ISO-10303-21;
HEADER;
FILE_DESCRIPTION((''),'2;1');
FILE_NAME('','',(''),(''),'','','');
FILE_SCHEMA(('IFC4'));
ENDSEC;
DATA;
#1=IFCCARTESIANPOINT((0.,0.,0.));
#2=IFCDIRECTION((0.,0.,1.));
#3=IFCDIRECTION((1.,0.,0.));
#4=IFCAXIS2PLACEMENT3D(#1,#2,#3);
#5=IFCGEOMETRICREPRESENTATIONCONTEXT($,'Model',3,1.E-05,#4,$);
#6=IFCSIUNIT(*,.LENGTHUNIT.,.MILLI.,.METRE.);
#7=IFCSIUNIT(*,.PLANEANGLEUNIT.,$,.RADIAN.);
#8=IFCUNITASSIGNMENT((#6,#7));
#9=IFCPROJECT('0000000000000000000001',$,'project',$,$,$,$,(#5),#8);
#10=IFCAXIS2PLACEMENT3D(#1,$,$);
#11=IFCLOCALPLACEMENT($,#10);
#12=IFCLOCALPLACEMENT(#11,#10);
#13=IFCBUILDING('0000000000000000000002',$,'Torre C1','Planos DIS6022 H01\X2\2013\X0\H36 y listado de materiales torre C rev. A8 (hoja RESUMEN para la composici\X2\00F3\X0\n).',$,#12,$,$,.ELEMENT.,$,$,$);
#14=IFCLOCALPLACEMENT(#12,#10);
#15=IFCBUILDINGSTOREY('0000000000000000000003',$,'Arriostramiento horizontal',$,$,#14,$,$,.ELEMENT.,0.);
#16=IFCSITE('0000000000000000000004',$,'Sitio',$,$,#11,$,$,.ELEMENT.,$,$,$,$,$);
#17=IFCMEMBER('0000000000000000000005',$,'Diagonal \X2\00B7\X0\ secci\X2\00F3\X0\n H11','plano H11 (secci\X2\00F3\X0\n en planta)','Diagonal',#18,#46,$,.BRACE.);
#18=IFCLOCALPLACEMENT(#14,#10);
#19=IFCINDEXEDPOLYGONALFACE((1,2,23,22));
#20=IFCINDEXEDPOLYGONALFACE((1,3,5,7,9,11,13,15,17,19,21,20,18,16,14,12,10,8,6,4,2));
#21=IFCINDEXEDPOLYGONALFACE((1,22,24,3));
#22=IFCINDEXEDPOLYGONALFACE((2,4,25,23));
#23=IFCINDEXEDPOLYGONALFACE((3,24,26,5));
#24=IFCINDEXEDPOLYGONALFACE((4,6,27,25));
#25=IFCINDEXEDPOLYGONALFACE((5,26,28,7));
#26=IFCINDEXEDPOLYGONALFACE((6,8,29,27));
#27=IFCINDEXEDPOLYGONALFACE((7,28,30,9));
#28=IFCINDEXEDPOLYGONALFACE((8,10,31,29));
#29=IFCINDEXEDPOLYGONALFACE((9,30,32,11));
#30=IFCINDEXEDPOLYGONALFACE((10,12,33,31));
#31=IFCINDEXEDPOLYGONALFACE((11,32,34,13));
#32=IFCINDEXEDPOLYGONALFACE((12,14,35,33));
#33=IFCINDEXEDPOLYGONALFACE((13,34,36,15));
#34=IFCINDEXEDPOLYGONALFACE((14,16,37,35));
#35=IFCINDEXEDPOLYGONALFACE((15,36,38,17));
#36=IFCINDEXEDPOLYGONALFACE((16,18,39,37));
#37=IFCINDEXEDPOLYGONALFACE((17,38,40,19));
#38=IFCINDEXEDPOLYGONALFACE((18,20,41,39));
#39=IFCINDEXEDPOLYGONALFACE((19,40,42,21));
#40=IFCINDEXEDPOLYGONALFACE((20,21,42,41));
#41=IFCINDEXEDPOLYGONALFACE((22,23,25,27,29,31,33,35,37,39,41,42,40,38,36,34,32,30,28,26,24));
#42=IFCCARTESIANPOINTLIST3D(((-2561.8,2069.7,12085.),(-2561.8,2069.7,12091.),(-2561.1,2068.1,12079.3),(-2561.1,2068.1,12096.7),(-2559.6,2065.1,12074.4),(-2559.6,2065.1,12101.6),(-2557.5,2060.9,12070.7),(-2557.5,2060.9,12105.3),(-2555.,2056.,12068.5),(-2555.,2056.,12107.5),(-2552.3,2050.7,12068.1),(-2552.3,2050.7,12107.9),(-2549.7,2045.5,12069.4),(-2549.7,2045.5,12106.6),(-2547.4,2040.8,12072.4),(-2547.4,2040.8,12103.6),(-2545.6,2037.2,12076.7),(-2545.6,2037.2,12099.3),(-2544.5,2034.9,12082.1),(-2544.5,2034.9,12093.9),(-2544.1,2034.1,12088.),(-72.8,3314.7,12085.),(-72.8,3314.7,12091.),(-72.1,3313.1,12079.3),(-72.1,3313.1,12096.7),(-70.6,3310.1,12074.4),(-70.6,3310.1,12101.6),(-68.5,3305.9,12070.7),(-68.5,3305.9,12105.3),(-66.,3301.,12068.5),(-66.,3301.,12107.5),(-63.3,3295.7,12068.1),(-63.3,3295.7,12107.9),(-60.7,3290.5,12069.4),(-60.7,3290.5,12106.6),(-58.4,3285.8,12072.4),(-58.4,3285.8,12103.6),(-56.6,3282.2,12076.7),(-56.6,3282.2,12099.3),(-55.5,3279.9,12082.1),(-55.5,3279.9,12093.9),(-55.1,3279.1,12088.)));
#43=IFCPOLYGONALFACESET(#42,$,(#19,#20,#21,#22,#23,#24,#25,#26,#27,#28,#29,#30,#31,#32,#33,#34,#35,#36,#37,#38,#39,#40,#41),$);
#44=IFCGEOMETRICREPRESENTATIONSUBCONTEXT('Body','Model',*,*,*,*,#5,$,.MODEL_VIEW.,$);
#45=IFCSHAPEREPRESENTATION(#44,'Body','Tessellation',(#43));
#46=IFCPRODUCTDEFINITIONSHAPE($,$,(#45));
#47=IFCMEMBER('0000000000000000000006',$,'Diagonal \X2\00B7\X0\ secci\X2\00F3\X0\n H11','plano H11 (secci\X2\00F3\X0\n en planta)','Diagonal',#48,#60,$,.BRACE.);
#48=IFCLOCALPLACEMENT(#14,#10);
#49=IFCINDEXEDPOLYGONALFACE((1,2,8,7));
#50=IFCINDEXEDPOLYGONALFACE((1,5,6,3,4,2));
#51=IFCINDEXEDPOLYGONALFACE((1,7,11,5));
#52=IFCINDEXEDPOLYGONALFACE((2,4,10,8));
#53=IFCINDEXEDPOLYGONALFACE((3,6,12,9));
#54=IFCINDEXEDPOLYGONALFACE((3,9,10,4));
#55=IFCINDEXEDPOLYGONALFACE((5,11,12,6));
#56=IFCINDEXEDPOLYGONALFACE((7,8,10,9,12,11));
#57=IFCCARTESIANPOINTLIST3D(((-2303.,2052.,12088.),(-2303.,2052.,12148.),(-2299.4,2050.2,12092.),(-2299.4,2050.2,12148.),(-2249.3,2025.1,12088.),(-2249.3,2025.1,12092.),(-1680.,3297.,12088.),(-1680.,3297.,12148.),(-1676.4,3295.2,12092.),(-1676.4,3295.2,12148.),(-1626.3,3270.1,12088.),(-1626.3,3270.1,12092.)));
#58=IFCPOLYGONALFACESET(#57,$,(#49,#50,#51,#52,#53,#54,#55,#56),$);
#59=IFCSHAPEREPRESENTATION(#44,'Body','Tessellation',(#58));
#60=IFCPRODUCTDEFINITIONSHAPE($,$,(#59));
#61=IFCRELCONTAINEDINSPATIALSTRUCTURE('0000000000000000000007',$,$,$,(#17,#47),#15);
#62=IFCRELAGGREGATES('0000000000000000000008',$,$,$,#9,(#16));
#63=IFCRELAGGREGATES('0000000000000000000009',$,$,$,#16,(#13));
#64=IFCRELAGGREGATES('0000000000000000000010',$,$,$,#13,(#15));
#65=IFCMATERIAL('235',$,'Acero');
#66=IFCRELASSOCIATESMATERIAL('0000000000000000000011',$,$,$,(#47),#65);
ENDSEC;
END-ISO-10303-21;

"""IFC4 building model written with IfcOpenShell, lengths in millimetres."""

from ifc_helpers import new_model, si_unit, frame, frame_2d, origin, origin_with_axes, place, context, subcontext, project, spatial, circle, l_section, extrude, material, element, save


model = new_model("IFC4")

# Units and contexts
model_context = context("Model", 3, precision=1e-05, world=origin_with_axes())
body_context = subcontext(model_context, "Body", "Model", "MODEL_VIEW")
ifc_project = project(units=[si_unit("LENGTHUNIT", "METRE", prefix="MILLI"), si_unit("PLANEANGLEUNIT", "RADIAN")], contexts=[model_context])

# Site, building, storey
site_placement = place(None, origin())
site = spatial("IfcSite", under=ifc_project, at=site_placement, Name="Sitio", CompositionType="ELEMENT")
building_placement = place(site_placement, origin())
building = spatial("IfcBuilding", under=site, at=building_placement, Name="Torre C1", Description="Planos DIS6022 H01–H36 y listado de materiales torre C rev. A8 (hoja RESUMEN para la composición).", CompositionType="ELEMENT")
storey_placement = place(building_placement, origin())
storey = spatial("IfcBuildingStorey", under=building, at=storey_placement, Name="Arriostramiento horizontal", CompositionType="ELEMENT", Elevation=0.0)

# Members
ifc_material = material(Name="235", Category="Acero")
member_1_placement = place(storey_placement, frame((-64.0, 3297.0, 12088.0), z_axis=(-0.894355, -0.447357, 0.0), x_axis=(0.447357, -0.894355, 0.0)))
element("IfcMember", 1, at=member_1_placement, inside=storey, Name="Diagonal · sección H11", Description="plano H11 (sección en planta)", ObjectType="Diagonal", PredefinedType="BRACE", context=body_context, shape_type="SweptSolid", body=[
    extrude(circle(Radius=20.0), None, (0.0, 0.0, 1.0), 2783.0),
])
member_2_placement = place(storey_placement, frame((-1680.0, 3297.0, 12088.0), z_axis=(-0.447501, -0.894283, 0.0), x_axis=(0.894283, -0.447501, 0.0)))
element("IfcMember", 2, at=member_2_placement, inside=storey, material=ifc_material, Name="Diagonal · sección H11", Description="plano H11 (sección en planta)", ObjectType="Diagonal", PredefinedType="BRACE", context=body_context, shape_type="SweptSolid", body=[
    extrude(l_section(Depth=60.0, Width=60.0, Thickness=4.0, at=frame_2d((30.0, 30.0))), None, (0.0, 0.0, 1.0), 1392.2),
])

save(model, "model.ifc")
